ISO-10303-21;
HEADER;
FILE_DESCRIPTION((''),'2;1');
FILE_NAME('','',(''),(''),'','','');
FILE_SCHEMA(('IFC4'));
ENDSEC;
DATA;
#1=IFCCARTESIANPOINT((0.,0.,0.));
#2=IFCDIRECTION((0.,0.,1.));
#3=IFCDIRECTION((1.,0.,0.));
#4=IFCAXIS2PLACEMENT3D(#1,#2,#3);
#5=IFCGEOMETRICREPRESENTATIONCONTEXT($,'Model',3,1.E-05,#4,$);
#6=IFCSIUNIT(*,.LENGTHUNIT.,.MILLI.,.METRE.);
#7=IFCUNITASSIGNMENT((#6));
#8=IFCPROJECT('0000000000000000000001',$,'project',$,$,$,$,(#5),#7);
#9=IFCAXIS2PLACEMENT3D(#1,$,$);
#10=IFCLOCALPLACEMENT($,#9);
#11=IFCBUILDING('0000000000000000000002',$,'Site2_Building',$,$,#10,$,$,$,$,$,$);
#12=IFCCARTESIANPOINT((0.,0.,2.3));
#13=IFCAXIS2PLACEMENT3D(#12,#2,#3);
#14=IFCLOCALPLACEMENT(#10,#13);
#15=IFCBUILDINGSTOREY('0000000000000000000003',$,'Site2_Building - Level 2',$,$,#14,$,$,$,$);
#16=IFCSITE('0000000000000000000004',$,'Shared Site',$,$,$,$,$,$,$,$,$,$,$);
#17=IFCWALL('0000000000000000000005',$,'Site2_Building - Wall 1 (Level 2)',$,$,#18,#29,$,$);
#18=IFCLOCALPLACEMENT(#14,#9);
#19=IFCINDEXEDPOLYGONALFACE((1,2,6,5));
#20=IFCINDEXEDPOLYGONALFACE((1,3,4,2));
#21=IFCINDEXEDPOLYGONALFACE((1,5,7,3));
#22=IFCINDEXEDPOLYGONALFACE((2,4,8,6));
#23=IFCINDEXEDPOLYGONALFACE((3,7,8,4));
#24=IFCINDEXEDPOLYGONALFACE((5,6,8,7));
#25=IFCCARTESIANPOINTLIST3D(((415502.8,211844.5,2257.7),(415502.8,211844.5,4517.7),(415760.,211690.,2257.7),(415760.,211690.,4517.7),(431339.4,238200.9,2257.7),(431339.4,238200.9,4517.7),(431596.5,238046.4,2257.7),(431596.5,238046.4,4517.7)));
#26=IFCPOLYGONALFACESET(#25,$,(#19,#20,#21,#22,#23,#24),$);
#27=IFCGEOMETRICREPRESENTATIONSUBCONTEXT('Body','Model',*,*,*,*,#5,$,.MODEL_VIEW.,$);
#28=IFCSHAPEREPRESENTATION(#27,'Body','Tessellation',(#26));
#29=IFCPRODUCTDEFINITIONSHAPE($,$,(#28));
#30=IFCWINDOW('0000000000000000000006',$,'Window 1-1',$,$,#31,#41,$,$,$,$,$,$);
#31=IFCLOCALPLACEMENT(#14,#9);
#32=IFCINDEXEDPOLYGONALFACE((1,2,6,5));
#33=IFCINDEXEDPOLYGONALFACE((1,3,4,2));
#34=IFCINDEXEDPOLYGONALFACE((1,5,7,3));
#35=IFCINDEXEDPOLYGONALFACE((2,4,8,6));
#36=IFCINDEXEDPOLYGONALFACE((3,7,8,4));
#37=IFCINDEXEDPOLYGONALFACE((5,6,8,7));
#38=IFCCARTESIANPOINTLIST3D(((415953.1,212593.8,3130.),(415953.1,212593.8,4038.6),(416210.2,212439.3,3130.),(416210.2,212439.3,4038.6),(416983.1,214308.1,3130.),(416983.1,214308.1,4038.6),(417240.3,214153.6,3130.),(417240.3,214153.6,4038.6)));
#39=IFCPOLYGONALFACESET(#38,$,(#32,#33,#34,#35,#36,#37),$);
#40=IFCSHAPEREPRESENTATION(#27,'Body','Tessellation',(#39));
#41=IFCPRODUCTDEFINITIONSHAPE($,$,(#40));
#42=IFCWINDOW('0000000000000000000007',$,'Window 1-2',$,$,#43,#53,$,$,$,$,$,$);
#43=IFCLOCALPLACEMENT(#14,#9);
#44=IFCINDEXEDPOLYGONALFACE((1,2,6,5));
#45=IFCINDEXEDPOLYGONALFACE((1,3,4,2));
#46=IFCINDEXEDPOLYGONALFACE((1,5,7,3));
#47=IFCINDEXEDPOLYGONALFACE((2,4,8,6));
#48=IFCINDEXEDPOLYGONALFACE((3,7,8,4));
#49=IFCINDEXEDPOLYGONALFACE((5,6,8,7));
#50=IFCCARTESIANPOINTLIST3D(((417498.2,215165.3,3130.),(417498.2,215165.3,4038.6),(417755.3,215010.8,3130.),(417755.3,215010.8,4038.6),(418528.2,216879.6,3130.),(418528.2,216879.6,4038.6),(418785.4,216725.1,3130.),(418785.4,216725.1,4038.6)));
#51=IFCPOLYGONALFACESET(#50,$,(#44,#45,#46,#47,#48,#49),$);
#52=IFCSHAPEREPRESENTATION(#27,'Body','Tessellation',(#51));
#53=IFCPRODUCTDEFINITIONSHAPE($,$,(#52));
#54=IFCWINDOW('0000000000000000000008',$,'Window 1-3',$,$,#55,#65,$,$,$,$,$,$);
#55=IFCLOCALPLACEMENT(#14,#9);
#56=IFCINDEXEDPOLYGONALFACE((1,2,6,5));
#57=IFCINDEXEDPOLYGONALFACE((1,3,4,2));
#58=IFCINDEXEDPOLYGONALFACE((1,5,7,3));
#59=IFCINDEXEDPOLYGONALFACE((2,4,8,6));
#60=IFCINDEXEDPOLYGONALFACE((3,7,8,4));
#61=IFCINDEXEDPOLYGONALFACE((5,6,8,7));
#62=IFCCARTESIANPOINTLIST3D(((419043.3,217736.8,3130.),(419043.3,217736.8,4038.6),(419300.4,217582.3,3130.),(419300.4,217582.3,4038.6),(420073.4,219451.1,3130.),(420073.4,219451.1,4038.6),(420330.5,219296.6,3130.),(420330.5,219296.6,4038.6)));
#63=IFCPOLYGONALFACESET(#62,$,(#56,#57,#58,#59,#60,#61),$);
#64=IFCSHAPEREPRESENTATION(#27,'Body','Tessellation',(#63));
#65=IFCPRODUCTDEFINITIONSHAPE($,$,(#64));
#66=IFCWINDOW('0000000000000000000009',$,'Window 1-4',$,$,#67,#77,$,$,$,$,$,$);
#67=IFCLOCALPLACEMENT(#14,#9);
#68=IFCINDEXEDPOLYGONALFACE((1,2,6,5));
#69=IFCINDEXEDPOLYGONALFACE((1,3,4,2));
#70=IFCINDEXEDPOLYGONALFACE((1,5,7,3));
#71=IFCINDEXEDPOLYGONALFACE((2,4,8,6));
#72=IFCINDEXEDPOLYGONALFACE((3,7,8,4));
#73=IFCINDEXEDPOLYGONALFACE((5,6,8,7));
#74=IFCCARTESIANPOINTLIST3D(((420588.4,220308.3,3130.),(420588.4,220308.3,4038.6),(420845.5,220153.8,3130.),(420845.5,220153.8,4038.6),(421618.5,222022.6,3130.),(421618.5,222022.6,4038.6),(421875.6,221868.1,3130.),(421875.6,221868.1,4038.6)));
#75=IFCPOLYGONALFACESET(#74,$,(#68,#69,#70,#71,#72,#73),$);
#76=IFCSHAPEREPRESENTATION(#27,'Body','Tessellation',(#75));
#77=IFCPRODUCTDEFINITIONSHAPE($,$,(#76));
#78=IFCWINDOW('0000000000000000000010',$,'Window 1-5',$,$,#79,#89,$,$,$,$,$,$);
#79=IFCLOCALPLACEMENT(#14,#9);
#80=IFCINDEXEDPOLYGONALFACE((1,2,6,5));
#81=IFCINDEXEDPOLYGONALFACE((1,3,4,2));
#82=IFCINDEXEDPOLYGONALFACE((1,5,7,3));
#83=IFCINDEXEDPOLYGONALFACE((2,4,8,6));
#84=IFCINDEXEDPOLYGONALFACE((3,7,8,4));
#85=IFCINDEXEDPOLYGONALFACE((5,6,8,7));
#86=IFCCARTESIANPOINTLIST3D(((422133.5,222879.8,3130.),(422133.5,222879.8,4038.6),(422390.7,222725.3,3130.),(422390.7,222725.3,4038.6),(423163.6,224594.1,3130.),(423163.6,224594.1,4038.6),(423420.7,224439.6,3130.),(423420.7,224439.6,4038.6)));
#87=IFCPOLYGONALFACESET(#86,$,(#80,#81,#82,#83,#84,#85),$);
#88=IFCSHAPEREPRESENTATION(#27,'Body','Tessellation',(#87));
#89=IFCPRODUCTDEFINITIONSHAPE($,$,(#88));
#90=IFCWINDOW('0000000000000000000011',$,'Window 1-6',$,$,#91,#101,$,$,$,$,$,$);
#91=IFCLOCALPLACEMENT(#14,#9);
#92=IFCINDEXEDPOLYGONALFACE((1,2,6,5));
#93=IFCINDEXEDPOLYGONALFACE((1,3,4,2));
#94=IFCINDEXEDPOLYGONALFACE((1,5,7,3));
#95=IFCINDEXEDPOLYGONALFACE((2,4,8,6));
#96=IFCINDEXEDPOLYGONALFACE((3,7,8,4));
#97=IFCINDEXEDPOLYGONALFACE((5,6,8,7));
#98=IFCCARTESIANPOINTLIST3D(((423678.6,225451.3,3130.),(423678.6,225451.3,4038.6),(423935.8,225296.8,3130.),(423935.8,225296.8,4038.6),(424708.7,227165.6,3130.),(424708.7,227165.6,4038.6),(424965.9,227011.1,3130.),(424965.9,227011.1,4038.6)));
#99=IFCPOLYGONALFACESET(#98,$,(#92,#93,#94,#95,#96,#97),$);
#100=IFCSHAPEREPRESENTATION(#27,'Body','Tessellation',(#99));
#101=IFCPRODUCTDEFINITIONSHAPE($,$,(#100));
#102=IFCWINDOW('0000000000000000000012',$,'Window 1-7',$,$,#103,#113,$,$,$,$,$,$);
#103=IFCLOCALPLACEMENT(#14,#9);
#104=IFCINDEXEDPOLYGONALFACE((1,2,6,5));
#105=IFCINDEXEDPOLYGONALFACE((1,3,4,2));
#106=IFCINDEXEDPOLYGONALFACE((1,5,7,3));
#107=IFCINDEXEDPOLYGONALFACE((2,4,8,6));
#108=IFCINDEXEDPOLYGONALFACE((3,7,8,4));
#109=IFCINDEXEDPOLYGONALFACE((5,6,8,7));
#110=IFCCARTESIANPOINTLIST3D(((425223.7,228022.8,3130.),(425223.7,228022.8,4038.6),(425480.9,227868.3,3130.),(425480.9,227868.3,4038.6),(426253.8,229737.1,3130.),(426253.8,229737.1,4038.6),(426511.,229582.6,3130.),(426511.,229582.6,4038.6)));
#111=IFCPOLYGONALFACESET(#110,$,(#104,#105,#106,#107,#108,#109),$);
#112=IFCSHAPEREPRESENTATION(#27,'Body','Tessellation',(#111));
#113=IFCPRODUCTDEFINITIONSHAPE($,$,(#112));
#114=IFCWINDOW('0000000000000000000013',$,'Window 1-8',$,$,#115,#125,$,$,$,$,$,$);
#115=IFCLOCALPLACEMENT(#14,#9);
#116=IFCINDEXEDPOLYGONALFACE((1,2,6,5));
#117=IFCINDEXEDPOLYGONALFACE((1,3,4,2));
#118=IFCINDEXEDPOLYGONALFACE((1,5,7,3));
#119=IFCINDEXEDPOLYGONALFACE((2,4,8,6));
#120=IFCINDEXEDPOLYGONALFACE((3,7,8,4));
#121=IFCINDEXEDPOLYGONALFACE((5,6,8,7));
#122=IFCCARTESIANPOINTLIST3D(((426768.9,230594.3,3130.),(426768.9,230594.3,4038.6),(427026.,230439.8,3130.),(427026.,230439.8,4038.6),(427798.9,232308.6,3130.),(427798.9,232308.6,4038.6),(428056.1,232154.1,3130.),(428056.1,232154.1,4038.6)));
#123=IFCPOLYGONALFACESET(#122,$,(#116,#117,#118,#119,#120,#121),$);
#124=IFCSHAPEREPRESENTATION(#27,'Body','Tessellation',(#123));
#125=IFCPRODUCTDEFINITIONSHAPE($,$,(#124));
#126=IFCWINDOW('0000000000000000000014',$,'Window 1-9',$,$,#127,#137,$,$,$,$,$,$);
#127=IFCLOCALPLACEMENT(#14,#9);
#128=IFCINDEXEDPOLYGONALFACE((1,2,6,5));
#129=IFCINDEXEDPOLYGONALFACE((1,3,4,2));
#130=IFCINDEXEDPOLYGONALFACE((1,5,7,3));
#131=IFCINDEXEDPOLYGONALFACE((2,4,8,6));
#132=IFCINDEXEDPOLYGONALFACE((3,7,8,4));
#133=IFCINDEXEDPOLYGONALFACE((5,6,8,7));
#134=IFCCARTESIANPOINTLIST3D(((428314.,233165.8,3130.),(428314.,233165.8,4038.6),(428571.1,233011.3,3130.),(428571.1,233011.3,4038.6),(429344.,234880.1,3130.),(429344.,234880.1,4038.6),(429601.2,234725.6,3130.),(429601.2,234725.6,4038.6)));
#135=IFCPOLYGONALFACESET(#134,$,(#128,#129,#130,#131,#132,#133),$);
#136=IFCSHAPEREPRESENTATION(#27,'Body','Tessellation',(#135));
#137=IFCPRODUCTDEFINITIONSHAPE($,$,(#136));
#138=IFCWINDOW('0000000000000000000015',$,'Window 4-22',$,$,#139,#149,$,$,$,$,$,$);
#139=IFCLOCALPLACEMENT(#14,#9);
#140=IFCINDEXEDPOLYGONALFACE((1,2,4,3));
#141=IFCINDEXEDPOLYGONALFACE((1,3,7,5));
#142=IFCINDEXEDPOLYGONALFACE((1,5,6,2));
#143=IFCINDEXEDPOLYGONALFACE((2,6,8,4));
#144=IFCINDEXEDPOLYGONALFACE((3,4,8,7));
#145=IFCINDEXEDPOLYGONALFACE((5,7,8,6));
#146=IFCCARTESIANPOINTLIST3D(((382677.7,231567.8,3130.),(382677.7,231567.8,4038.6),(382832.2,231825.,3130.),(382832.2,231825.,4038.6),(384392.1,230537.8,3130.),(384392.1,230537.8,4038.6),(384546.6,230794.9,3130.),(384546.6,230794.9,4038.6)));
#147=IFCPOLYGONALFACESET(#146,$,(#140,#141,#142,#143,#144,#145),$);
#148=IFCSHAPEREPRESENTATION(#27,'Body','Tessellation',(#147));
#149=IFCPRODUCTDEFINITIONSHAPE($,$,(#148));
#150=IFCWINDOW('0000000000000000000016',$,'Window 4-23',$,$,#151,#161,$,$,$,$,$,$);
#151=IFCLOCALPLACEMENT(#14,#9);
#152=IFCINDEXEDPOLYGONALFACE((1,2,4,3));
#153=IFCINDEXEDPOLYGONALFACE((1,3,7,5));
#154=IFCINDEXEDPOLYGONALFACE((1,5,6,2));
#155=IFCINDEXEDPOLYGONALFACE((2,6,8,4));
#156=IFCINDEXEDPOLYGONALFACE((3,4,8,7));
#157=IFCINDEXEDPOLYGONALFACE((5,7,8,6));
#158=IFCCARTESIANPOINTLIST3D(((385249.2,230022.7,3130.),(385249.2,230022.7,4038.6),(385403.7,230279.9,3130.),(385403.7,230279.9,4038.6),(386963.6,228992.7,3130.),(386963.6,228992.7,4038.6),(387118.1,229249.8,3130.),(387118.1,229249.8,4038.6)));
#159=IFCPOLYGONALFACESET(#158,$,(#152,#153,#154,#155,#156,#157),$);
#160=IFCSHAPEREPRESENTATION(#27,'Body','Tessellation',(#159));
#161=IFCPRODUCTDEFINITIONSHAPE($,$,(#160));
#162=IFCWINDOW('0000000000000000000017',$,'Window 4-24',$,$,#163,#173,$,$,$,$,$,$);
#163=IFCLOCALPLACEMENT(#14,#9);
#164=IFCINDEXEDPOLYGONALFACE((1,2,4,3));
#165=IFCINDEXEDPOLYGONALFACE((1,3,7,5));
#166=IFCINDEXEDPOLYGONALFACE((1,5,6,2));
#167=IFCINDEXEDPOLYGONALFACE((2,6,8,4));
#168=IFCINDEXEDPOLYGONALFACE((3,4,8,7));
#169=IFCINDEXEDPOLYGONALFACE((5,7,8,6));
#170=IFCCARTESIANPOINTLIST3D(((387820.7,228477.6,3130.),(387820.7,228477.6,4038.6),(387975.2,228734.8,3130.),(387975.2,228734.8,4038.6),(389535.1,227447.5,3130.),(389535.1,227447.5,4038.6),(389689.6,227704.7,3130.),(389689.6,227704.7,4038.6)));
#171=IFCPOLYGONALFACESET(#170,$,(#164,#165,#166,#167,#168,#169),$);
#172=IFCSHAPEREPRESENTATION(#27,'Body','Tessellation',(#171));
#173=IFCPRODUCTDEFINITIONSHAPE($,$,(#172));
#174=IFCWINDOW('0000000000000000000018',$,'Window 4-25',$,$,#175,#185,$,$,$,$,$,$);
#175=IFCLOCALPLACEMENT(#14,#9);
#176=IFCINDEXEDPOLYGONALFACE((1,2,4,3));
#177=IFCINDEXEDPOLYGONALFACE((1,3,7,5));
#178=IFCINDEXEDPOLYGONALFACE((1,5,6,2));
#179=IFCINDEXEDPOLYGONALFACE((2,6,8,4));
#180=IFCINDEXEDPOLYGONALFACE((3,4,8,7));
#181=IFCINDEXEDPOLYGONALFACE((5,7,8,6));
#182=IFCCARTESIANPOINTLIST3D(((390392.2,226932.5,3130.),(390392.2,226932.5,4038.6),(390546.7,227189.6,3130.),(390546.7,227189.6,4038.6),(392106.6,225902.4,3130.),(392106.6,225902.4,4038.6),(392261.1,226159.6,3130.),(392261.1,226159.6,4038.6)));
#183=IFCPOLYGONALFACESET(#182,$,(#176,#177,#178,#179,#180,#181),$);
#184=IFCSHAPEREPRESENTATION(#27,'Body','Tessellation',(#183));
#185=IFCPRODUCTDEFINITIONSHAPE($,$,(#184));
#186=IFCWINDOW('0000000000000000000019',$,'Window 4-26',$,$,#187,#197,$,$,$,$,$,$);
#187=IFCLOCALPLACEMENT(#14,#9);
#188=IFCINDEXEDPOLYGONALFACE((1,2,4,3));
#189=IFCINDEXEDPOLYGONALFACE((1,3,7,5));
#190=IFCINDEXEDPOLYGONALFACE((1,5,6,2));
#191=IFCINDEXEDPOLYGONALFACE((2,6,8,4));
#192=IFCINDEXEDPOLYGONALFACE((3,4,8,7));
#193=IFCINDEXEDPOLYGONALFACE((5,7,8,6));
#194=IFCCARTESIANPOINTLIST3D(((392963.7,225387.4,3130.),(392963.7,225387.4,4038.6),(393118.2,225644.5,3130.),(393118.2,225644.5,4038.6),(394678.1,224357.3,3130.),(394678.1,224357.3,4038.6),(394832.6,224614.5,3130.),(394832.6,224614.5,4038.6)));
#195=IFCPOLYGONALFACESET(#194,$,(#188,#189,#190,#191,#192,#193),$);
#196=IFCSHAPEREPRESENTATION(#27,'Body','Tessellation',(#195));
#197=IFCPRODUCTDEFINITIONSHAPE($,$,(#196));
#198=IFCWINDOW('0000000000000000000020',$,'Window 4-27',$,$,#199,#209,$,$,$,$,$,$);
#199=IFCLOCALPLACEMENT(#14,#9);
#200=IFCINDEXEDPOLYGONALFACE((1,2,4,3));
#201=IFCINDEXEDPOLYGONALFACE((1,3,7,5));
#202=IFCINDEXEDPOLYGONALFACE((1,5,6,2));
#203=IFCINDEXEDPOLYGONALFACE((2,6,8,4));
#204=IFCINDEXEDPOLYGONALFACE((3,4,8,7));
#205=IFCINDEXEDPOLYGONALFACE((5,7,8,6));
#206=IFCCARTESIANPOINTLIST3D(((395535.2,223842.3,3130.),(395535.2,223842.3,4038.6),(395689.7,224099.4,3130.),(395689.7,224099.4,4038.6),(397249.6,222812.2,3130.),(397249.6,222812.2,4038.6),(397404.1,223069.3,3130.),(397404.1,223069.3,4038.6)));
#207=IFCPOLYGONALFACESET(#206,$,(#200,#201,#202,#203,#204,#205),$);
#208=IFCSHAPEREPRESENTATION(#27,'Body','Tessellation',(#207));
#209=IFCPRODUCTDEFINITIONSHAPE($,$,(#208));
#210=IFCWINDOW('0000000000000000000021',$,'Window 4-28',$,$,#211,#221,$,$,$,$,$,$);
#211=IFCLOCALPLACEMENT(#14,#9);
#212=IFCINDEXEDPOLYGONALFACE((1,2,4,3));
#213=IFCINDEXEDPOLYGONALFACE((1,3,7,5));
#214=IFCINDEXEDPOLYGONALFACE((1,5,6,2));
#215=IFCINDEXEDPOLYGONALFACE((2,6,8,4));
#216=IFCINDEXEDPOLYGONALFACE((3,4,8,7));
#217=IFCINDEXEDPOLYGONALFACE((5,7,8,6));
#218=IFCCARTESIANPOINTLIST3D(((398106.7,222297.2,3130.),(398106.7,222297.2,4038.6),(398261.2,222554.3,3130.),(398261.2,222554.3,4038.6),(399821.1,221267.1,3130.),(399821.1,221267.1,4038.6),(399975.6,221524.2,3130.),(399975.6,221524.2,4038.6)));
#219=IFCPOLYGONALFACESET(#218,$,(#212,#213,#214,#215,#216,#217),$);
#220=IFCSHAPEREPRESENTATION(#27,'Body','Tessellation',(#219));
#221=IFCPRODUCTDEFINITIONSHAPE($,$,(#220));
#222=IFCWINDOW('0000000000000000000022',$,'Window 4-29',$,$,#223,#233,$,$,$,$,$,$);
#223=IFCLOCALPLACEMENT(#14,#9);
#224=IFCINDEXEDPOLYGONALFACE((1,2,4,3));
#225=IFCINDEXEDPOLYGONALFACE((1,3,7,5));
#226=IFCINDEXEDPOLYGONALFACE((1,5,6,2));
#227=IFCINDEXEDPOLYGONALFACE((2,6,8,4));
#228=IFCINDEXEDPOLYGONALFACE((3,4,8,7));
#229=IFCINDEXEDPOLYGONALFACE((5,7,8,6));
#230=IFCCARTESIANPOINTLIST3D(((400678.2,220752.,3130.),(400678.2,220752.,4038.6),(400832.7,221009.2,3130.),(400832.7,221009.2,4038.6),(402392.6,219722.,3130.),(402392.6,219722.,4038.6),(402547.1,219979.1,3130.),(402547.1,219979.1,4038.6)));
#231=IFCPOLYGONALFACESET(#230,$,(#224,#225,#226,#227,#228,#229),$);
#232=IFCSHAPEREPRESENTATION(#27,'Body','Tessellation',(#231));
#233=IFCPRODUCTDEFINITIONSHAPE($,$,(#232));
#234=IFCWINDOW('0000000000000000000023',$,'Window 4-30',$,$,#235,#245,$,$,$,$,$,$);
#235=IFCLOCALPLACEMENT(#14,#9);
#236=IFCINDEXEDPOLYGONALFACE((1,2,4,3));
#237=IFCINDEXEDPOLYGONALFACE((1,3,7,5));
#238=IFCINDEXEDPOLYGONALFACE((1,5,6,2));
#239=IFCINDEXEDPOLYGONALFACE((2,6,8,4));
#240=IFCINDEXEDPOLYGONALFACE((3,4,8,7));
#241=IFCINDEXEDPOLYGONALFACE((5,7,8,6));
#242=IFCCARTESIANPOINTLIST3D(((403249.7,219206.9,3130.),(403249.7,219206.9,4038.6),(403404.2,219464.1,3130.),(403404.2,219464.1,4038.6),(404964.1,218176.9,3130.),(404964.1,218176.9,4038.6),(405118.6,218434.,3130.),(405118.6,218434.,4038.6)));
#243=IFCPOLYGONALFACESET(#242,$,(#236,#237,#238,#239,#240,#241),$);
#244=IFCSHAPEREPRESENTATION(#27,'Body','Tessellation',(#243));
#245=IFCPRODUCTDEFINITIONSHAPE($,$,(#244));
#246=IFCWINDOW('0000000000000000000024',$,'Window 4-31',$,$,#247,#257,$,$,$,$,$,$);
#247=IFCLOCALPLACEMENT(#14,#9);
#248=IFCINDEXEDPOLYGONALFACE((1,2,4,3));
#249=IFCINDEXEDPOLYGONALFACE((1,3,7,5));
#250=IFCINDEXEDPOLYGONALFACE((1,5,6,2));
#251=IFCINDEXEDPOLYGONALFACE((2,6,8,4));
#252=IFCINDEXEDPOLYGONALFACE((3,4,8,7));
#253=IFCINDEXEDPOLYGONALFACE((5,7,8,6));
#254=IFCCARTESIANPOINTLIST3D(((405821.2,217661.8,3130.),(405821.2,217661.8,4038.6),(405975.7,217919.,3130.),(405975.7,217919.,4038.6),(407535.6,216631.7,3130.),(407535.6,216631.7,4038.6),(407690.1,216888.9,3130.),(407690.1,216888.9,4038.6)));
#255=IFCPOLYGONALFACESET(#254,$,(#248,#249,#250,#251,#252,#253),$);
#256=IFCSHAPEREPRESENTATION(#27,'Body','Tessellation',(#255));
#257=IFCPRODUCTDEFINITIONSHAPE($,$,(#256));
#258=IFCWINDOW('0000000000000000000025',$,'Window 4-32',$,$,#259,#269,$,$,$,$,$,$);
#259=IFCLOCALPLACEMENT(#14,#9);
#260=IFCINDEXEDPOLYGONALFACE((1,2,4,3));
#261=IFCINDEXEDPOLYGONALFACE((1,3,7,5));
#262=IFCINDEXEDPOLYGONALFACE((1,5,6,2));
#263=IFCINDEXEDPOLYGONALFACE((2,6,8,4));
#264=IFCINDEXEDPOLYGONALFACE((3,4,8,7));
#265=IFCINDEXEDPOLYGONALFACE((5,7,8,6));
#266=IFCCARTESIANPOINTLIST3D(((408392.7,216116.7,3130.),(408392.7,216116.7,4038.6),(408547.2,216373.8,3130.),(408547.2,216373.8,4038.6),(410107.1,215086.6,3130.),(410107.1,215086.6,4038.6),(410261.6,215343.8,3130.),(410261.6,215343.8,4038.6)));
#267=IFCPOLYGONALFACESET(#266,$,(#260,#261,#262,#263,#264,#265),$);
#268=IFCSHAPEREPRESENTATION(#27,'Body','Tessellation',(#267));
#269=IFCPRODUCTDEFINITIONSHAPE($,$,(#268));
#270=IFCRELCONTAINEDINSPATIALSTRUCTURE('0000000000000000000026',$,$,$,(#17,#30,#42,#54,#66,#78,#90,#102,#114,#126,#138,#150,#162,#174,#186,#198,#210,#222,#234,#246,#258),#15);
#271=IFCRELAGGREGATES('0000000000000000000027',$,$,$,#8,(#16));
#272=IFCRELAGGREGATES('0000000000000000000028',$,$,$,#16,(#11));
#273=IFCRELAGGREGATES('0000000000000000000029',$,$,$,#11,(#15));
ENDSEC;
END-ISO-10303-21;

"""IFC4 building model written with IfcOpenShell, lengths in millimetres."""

from ifc_helpers import new_model, si_unit, frame, origin, origin_with_axes, place, context, subcontext, project, spatial, indexed_curve, outline, extrude, element, save


model = new_model("IFC4")

# Units and contexts
model_context = context("Model", 3, precision=1e-05, world=origin_with_axes())
body_context = subcontext(model_context, "Body", "Model", "MODEL_VIEW")
ifc_project = project(units=[si_unit("LENGTHUNIT", "METRE", prefix="MILLI")], contexts=[model_context])

# Site, building, storey
site = spatial("IfcSite", under=ifc_project, Name="Shared Site")
building_placement = place(None, origin())
building = spatial("IfcBuilding", under=site, at=building_placement, Name="Site2_Building")
storey_placement = place(building_placement, frame((0.0, 0.0, 2.3), z_axis=(0.0, 0.0, 1.0), x_axis=(1.0, 0.0, 0.0)))
storey = spatial("IfcBuildingStorey", under=building, at=storey_placement, Name="Site2_Building - Level 2")

# Wall
wall_placement = place(storey_placement, frame((415760.0, 211690.0, 2257.7), z_axis=(0.0, 0.0, 1.0), x_axis=(0.515038, 0.857167, 0.0)))
element("IfcWall", 1, at=wall_placement, inside=storey, Name="Site2_Building - Wall 1 (Level 2)", context=body_context, shape_type="SweptSolid", body=[
    extrude(outline(indexed_curve([(0.0, 0.0), (0.0, 300.0), (30748.2, 300.0), (30748.2, 0.0), (0.0, 0.0)], self_intersect=False)), origin_with_axes(), (0.0, 0.0, 1.0), 2260.0),
])

# Windows
for number, where, z_axis, x_axis, name in (
    (2, (416210.2, 212439.3, 3130.0), (0.0, 0.0, 1.0), (0.515038, 0.857167, 0.0), "Window 1-1"),
    (3, (417755.3, 215010.8, 3130.0), (0.0, 0.0, 1.0), (0.515038, 0.857167, 0.0), "Window 1-2"),
    (4, (419300.4, 217582.3, 3130.0), (0.0, 0.0, 1.0), (0.515038, 0.857167, 0.0), "Window 1-3"),
    (5, (420845.5, 220153.8, 3130.0), (0.0, 0.0, 1.0), (0.515038, 0.857167, 0.0), "Window 1-4"),
    (6, (422390.7, 222725.3, 3130.0), (0.0, 0.0, 1.0), (0.515038, 0.857167, 0.0), "Window 1-5"),
    (7, (423935.8, 225296.8, 3130.0), (0.0, 0.0, 1.0), (0.515038, 0.857167, 0.0), "Window 1-6"),
    (8, (425480.9, 227868.3, 3130.0), (0.0, 0.0, 1.0), (0.515038, 0.857167, 0.0), "Window 1-7"),
    (9, (427026.0, 230439.8, 3130.0), (0.0, 0.0, 1.0), (0.515038, 0.857167, 0.0), "Window 1-8"),
    (10, (428571.1, 233011.3, 3130.0), (0.0, 0.0, 1.0), (0.515038, 0.857167, 0.0), "Window 1-9"),
    (11, (382677.7, 231567.8, 3130.0), (0.0, 0.0, 1.0), (0.857167, -0.515038, 0.0), "Window 4-22"),
    (12, (385249.2, 230022.7, 3130.0), (0.0, 0.0, 1.0), (0.857167, -0.515038, 0.0), "Window 4-23"),
    (13, (387820.7, 228477.6, 3130.0), (0.0, 0.0, 1.0), (0.857167, -0.515038, 0.0), "Window 4-24"),
    (14, (390392.2, 226932.5, 3130.0), (0.0, 0.0, 1.0), (0.857167, -0.515038, 0.0), "Window 4-25"),
    (15, (392963.7, 225387.4, 3130.0), (0.0, 0.0, 1.0), (0.857167, -0.515038, 0.0), "Window 4-26"),
    (16, (395535.2, 223842.3, 3130.0), (0.0, 0.0, 1.0), (0.857167, -0.515038, 0.0), "Window 4-27"),
    (17, (398106.7, 222297.2, 3130.0), (0.0, 0.0, 1.0), (0.857167, -0.515038, 0.0), "Window 4-28"),
    (18, (400678.2, 220752.0, 3130.0), (0.0, 0.0, 1.0), (0.857167, -0.515038, 0.0), "Window 4-29"),
    (19, (403249.7, 219206.9, 3130.0), (0.0, 0.0, 1.0), (0.857167, -0.515038, 0.0), "Window 4-30"),
    (20, (405821.2, 217661.8, 3130.0), (0.0, 0.0, 1.0), (0.857167, -0.515038, 0.0), "Window 4-31"),
    (21, (408392.7, 216116.7, 3130.0), (0.0, 0.0, 1.0), (0.857167, -0.515038, 0.0), "Window 4-32"),
):
    element("IfcWindow", number, at=place(storey_placement, frame(where, z_axis=z_axis, x_axis=x_axis)), inside=storey, Name=name, context=body_context, shape_type="SweptSolid", body=[
        extrude(outline(indexed_curve([(0.0, 0.0), (0.0, 300.0), (2000.0, 300.0), (2000.0, 0.0), (0.0, 0.0)], self_intersect=False)), origin_with_axes(), (0.0, 0.0, 1.0), 908.6),
    ])

save(model, "model.ifc")
